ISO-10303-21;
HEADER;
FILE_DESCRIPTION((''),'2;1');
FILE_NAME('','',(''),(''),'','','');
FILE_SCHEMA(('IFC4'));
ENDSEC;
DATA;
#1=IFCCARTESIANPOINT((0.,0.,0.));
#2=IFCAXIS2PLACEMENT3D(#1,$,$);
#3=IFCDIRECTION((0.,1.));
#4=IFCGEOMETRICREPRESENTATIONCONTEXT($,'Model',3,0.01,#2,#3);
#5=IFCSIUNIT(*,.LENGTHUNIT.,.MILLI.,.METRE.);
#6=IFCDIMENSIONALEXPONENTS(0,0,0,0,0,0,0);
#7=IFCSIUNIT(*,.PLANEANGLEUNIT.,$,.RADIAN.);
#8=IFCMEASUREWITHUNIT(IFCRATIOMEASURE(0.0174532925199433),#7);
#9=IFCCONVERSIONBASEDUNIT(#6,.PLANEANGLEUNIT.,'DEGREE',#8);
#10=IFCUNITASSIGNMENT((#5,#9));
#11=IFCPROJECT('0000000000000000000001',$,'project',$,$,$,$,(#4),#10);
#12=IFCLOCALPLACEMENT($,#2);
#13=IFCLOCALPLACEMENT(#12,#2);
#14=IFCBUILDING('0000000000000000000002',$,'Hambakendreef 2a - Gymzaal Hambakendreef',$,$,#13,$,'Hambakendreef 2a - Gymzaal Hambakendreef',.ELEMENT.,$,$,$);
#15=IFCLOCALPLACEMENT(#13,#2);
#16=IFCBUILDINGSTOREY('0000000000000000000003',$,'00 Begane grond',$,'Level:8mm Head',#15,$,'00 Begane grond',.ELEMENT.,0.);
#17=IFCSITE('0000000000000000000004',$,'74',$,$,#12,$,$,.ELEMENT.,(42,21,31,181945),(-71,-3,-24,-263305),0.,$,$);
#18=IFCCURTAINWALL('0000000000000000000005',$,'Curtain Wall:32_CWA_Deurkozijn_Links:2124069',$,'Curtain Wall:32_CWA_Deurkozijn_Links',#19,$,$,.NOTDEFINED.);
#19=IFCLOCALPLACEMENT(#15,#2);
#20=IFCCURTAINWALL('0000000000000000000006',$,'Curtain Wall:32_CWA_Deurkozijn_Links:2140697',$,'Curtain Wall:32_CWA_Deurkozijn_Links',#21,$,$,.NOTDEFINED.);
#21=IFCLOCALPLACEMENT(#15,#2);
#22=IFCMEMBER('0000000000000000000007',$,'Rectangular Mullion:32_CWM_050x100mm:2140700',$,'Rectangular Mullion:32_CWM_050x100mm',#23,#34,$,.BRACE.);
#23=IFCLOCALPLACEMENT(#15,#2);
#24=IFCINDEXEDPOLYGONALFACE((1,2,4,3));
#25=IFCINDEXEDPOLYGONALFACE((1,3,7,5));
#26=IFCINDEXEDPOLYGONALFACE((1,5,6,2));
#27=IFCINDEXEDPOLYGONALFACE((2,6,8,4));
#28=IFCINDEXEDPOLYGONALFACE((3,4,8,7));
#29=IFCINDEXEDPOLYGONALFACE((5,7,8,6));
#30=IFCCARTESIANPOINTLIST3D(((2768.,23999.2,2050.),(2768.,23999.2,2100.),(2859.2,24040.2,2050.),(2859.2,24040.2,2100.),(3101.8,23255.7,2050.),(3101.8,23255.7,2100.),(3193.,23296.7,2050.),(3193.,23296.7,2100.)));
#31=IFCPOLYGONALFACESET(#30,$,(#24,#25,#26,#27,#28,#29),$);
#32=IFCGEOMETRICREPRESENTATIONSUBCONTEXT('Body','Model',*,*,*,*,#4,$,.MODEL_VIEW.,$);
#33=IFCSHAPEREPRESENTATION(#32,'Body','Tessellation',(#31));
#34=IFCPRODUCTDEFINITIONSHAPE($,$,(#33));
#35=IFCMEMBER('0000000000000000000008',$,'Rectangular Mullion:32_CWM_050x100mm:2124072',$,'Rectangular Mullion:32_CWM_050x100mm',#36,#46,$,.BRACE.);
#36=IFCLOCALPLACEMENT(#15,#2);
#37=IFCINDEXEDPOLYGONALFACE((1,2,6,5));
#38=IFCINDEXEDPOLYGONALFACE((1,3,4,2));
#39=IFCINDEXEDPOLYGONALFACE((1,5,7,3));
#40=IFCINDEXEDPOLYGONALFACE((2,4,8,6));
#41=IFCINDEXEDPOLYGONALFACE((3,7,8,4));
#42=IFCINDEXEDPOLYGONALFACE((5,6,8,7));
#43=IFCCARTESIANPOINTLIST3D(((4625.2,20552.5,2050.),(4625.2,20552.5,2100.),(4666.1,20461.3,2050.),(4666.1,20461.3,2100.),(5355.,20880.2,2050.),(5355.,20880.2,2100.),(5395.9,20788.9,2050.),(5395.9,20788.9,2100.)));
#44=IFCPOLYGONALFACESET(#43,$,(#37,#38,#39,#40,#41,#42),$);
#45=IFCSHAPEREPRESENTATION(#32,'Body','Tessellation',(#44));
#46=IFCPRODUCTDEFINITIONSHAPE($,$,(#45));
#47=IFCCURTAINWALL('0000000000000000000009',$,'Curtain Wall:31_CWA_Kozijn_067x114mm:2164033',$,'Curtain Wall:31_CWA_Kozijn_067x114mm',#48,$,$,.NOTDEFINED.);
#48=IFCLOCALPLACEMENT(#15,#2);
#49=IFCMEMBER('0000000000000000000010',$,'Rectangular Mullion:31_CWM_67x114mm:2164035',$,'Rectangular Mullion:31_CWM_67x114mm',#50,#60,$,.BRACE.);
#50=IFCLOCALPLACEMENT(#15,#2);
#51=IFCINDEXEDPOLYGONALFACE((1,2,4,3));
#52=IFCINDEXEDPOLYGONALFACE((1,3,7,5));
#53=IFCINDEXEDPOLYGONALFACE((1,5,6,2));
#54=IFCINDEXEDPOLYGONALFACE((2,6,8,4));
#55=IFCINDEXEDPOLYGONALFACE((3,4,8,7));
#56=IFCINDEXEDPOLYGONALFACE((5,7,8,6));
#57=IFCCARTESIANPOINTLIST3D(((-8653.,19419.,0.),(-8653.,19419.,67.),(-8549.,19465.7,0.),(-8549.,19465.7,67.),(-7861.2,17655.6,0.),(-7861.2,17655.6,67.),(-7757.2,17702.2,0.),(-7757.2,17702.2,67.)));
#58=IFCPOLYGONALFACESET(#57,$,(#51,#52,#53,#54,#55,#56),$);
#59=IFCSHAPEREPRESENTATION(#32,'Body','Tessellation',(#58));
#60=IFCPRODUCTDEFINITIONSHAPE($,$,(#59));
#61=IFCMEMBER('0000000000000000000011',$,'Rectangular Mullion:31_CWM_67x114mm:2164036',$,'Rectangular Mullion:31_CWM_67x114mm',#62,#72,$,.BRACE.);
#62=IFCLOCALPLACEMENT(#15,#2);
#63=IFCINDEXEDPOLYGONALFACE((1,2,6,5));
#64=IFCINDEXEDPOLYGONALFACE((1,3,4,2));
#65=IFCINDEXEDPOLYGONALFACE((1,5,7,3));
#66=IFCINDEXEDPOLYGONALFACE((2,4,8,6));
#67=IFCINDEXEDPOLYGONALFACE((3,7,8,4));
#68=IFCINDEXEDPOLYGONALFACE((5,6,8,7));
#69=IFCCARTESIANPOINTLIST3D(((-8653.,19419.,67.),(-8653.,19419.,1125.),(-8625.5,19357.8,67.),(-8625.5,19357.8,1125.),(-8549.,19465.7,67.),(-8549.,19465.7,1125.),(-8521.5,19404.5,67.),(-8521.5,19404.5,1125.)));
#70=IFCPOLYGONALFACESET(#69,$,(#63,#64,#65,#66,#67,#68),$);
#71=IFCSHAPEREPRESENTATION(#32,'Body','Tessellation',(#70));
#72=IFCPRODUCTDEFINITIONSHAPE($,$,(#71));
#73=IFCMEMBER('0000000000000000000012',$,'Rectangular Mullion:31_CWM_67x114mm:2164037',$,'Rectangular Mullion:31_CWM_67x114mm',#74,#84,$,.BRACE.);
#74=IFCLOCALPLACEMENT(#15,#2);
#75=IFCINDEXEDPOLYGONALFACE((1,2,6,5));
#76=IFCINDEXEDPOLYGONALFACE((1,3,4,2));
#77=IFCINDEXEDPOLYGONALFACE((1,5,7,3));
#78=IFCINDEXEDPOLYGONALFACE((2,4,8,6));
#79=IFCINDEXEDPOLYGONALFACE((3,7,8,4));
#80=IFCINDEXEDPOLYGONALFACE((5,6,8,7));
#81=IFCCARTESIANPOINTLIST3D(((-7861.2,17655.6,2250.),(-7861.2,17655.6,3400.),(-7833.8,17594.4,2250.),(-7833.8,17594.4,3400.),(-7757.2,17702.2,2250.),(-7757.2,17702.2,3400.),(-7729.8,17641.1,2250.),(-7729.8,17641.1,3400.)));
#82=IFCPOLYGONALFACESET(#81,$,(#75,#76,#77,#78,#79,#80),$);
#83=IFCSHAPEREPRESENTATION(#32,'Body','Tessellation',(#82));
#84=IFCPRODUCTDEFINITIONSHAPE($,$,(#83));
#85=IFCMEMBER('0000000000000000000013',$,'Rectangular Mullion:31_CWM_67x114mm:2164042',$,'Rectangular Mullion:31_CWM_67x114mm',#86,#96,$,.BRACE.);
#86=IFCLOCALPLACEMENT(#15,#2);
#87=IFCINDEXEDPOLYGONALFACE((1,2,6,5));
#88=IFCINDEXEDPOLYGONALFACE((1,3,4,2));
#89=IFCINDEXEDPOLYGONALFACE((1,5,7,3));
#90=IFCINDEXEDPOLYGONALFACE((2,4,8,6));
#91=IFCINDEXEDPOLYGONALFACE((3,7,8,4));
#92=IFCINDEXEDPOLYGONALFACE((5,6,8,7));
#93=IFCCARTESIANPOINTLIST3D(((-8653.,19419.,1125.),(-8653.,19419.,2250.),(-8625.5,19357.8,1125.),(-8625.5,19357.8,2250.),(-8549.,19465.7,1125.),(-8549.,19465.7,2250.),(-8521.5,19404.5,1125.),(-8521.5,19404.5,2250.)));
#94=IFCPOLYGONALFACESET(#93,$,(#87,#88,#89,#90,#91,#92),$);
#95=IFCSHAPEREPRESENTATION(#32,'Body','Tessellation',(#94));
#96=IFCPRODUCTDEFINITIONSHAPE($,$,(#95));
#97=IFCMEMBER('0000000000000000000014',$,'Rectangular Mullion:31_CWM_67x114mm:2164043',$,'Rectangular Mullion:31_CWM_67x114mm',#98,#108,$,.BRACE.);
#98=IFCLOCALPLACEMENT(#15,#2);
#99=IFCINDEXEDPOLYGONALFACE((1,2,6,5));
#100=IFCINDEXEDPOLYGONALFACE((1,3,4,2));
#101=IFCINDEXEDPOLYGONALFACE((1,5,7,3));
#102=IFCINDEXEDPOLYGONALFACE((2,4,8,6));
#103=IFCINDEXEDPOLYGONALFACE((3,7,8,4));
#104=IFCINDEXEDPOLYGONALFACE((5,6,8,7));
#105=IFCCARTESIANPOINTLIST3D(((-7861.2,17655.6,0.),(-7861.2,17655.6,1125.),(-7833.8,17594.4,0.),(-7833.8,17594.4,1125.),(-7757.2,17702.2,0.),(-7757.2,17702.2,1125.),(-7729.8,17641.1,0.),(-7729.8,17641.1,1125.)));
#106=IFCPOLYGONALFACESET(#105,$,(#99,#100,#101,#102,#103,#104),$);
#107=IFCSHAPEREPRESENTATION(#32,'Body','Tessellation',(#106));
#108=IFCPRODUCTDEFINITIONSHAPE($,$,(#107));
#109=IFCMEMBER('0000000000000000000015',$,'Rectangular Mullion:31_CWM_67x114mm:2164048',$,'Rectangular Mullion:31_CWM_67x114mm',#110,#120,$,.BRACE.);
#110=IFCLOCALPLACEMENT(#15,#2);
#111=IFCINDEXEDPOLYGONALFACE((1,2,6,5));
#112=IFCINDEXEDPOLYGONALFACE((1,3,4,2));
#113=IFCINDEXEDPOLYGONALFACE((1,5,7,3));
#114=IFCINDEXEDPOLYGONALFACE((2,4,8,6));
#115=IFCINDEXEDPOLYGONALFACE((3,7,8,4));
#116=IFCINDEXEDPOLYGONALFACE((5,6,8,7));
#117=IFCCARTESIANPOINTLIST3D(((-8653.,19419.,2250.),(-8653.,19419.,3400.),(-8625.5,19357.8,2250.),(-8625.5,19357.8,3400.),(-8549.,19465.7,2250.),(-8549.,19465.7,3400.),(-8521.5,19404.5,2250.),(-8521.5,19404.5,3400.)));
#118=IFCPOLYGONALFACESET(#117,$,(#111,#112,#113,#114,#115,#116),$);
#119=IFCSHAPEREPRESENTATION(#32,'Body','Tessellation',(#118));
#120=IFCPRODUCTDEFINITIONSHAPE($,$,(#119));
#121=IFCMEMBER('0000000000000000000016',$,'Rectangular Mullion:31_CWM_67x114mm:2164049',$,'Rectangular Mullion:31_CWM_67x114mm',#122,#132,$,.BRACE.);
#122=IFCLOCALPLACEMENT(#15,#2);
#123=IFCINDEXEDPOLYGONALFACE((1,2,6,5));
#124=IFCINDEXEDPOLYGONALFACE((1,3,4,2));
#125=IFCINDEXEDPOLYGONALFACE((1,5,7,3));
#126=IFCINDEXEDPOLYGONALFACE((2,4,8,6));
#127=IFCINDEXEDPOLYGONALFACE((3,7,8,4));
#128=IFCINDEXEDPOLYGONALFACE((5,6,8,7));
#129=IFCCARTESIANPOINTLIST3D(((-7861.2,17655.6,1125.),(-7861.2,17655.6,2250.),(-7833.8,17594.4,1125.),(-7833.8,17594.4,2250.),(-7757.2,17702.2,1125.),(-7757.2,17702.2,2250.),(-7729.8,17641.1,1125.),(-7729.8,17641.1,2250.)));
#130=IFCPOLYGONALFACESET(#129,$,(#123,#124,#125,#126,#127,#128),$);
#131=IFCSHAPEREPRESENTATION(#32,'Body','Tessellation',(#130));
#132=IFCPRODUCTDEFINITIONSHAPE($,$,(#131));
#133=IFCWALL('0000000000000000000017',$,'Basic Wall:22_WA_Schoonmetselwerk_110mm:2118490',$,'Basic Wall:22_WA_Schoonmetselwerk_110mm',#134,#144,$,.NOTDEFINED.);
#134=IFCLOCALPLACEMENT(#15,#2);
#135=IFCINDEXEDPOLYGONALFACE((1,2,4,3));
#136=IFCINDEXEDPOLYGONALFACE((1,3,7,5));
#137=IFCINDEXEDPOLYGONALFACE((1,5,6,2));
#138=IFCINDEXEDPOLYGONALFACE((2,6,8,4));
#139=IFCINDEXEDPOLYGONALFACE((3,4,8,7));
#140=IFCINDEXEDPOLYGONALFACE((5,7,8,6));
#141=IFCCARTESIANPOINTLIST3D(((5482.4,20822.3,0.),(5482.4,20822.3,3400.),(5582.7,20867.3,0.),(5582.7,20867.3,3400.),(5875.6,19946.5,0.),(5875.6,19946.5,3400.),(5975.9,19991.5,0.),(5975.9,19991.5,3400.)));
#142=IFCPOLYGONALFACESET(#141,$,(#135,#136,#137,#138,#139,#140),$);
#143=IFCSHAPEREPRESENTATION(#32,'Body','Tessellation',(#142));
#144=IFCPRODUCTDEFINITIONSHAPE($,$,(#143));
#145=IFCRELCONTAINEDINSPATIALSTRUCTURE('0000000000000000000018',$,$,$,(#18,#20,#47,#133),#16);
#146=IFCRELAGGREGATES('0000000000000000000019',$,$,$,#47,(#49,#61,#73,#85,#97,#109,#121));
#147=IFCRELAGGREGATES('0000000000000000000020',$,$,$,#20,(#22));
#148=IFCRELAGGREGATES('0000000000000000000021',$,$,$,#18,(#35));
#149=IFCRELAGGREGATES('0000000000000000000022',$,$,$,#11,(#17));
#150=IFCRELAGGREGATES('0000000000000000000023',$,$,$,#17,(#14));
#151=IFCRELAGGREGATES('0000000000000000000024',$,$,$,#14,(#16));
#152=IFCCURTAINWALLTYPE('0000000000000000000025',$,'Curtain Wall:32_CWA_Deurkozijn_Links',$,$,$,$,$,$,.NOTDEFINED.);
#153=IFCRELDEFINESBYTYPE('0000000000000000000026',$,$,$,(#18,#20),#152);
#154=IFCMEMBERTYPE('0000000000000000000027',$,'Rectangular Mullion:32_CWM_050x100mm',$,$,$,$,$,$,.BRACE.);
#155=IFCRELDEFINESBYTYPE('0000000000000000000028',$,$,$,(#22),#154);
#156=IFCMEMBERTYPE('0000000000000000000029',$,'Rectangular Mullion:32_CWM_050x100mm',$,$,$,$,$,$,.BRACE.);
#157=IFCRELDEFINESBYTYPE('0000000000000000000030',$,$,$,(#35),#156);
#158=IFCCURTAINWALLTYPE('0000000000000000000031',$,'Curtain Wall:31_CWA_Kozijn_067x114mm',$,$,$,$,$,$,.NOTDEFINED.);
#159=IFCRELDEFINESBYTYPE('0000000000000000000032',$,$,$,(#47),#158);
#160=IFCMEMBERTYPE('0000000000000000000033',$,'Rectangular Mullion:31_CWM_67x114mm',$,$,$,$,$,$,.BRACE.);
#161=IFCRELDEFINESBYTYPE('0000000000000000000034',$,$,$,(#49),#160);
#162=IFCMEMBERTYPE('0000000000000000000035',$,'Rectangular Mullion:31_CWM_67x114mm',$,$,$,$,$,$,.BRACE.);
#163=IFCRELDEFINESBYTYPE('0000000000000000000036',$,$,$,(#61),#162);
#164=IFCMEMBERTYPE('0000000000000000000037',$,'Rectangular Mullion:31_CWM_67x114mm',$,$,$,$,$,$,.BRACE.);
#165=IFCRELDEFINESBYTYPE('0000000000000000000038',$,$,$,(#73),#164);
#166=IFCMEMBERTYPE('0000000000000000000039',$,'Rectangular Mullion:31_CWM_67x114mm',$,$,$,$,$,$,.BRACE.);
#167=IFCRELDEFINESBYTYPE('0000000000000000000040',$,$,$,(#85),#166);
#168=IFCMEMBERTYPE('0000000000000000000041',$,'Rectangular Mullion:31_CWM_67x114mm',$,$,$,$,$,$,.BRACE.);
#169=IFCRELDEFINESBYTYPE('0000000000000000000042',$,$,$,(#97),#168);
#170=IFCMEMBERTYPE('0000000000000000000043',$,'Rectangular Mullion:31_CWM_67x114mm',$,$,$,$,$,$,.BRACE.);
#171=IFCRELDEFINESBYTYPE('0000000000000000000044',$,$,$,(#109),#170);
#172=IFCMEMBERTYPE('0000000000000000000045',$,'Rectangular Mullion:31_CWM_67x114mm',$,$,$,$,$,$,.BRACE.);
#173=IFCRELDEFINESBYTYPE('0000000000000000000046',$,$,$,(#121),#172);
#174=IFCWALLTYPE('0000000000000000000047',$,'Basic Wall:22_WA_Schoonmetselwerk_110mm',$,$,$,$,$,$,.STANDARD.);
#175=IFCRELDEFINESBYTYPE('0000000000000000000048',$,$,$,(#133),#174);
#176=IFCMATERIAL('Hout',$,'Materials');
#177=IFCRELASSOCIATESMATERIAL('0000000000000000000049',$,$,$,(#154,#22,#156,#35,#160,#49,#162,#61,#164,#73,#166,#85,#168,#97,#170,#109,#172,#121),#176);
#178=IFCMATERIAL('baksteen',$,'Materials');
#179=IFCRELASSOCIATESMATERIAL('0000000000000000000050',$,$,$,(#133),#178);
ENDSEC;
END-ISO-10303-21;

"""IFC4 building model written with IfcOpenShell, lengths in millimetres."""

from ifc_helpers import new_model, entity, si_unit, converted_unit, direction, frame, origin, place, context, subcontext, project, spatial, indexed_curve, outline, extrude, source, transform, mapped, material, type_object, type_shapes, element, aggregate, save


model = new_model("IFC4")

# Units and contexts
model_context = context("Model", 3, precision=0.01, world=origin(), true_north=direction((0.0, 1.0)))
body_context = subcontext(model_context, "Body", "Model", "MODEL_VIEW")
ifc_project = project(units=[si_unit("LENGTHUNIT", "METRE", prefix="MILLI"), converted_unit("PLANEANGLEUNIT", "DEGREE", entity("IfcRatioMeasure", 0.0174532925199433), si_unit("PLANEANGLEUNIT", "RADIAN"), dimensions=[0, 0, 0, 0, 0, 0, 0])], contexts=[model_context])

# Site, building, storey
site_placement = place(None, origin())
site = spatial("IfcSite", under=ifc_project, at=site_placement, Name="74", CompositionType="ELEMENT", RefLatitude=(42, 21, 31, 181945), RefLongitude=(-71, -3, -24, -263305), RefElevation=0.0)
building_placement = place(site_placement, origin())
building = spatial("IfcBuilding", under=site, at=building_placement, Name="Hambakendreef 2a - Gymzaal Hambakendreef", LongName="Hambakendreef 2a - Gymzaal Hambakendreef", CompositionType="ELEMENT")
storey_placement = place(building_placement, origin())
storey = spatial("IfcBuildingStorey", under=building, at=storey_placement, Name="00 Begane grond", ObjectType="Level:8mm Head", LongName="00 Begane grond", CompositionType="ELEMENT", Elevation=0.0)

# Curtain walls
curtain_wall_type_1 = type_object("IfcCurtainWallType", Name="Curtain Wall:32_CWA_Deurkozijn_Links", PredefinedType="NOTDEFINED")
curtain_wall_1_placement = place(storey_placement, origin())
curtain_wall_1 = element("IfcCurtainWall", 1, at=curtain_wall_1_placement, inside=storey, type_object=curtain_wall_type_1, Name="Curtain Wall:32_CWA_Deurkozijn_Links:2124069", ObjectType="Curtain Wall:32_CWA_Deurkozijn_Links", PredefinedType="NOTDEFINED")
ifc_material_1 = material(Name="Hout", Category="Materials")
curtain_wall_2_placement = place(storey_placement, origin())
curtain_wall_2 = element("IfcCurtainWall", 2, at=curtain_wall_2_placement, inside=storey, type_object=curtain_wall_type_1, Name="Curtain Wall:32_CWA_Deurkozijn_Links:2140697", ObjectType="Curtain Wall:32_CWA_Deurkozijn_Links", PredefinedType="NOTDEFINED")

# Members
member_type_1 = type_object("IfcMemberType", Name="Rectangular Mullion:32_CWM_050x100mm", PredefinedType="BRACE", material=ifc_material_1)
shared_shape_1 = source(origin(), body_context, "Body", "SweptSolid", [
    extrude(outline(indexed_curve([(-50.0, -25.0), (50.0, -25.0), (50.0, 25.0), (-50.0, 25.0), (-50.0, -25.0)], self_intersect=False)), frame((-25.0, 0.0, -815.0), z_axis=(0.0, 0.0, 1.0), x_axis=(0.0, -1.0, 0.0)), (0.0, 0.0, 1.0), 815.0),
])
type_shapes(member_type_1, [shared_shape_1])
member_1_placement = place(storey_placement, frame((3147.4, 23276.2, 2100.0), z_axis=(0.40959, -0.91227, 0.0), x_axis=(0.0, 0.0, 1.0)))
member_1 = element("IfcMember", 3, at=member_1_placement, type_object=member_type_1, material=ifc_material_1, Name="Rectangular Mullion:32_CWM_050x100mm:2140700", ObjectType="Rectangular Mullion:32_CWM_050x100mm", PredefinedType="BRACE", context=body_context, shape_type="MappedRepresentation", body=[
    mapped(shared_shape_1, transform((0.0, 0.0, 0.0), scale=1.0)),
])
member_type_2 = type_object("IfcMemberType", Name="Rectangular Mullion:32_CWM_050x100mm", PredefinedType="BRACE", material=ifc_material_1)
shared_shape_2 = source(origin(), body_context, "Body", "SweptSolid", [
    extrude(outline(indexed_curve([(-50.0, -25.0), (50.0, -25.0), (50.0, 25.0), (-50.0, 25.0), (-50.0, -25.0)], self_intersect=False)), frame((-25.0, 0.0, -800.0), z_axis=(0.0, 0.0, 1.0), x_axis=(0.0, -1.0, 0.0)), (0.0, 0.0, 1.0), 800.0),
])
type_shapes(member_type_2, [shared_shape_2])
member_2_placement = place(storey_placement, frame((5375.5, 20834.6, 2100.0), z_axis=(0.91227, 0.40959, 0.0), x_axis=(0.0, 0.0, 1.0)))
member_2 = element("IfcMember", 4, at=member_2_placement, type_object=member_type_2, material=ifc_material_1, Name="Rectangular Mullion:32_CWM_050x100mm:2124072", ObjectType="Rectangular Mullion:32_CWM_050x100mm", PredefinedType="BRACE", context=body_context, shape_type="MappedRepresentation", body=[
    mapped(shared_shape_2, transform((0.0, 0.0, 0.0), scale=1.0)),
])

# Curtain wall, members
curtain_wall_type_2 = type_object("IfcCurtainWallType", Name="Curtain Wall:31_CWA_Kozijn_067x114mm", PredefinedType="NOTDEFINED")
curtain_wall_3_placement = place(storey_placement, origin())
curtain_wall_3 = element("IfcCurtainWall", 5, at=curtain_wall_3_placement, inside=storey, type_object=curtain_wall_type_2, Name="Curtain Wall:31_CWA_Kozijn_067x114mm:2164033", ObjectType="Curtain Wall:31_CWA_Kozijn_067x114mm", PredefinedType="NOTDEFINED")
member_type_3 = type_object("IfcMemberType", Name="Rectangular Mullion:31_CWM_67x114mm", PredefinedType="BRACE", material=ifc_material_1)
shared_shape_3 = source(origin(), body_context, "Body", "SweptSolid", [
    extrude(outline(indexed_curve([(-57.0, -33.5), (57.0, -33.5), (57.0, 33.5), (-57.0, 33.5), (-57.0, -33.5)], self_intersect=False)), frame((-33.5, 0.0, -1933.0), z_axis=(0.0, 0.0, 1.0), x_axis=(0.0, -1.0, 0.0)), (0.0, 0.0, 1.0), 1933.0),
])
type_shapes(member_type_3, [shared_shape_3])
member_3_placement = place(storey_placement, frame((-7809.2, 17678.9, 0.0), z_axis=(0.40959, -0.91227, 0.0), x_axis=(0.0, 0.0, -1.0)))
member_3 = element("IfcMember", 6, at=member_3_placement, type_object=member_type_3, material=ifc_material_1, Name="Rectangular Mullion:31_CWM_67x114mm:2164035", ObjectType="Rectangular Mullion:31_CWM_67x114mm", PredefinedType="BRACE", context=body_context, shape_type="MappedRepresentation", body=[
    mapped(shared_shape_3, transform((0.0, 0.0, 0.0), scale=1.0)),
])
member_type_4 = type_object("IfcMemberType", Name="Rectangular Mullion:31_CWM_67x114mm", PredefinedType="BRACE", material=ifc_material_1)
shared_shape_4 = source(origin(), body_context, "Body", "SweptSolid", [
    extrude(outline(indexed_curve([(-57.0, -33.5), (57.0, -33.5), (57.0, 33.5), (-57.0, 33.5), (-57.0, -33.5)], self_intersect=False)), frame((-33.5, 0.0, -1058.0), z_axis=(0.0, 0.0, 1.0), x_axis=(0.0, -1.0, 0.0)), (0.0, 0.0, 1.0), 1058.0),
])
type_shapes(member_type_4, [shared_shape_4])
member_4_placement = place(storey_placement, frame((-8601.0, 19442.3, 67.0), z_axis=(0.0, 0.0, -1.0), x_axis=(-0.40959, 0.91227, 0.0)))
member_4 = element("IfcMember", 7, at=member_4_placement, type_object=member_type_4, material=ifc_material_1, Name="Rectangular Mullion:31_CWM_67x114mm:2164036", ObjectType="Rectangular Mullion:31_CWM_67x114mm", PredefinedType="BRACE", context=body_context, shape_type="MappedRepresentation", body=[
    mapped(shared_shape_4, transform((0.0, 0.0, 0.0), scale=1.0)),
])
member_type_5 = type_object("IfcMemberType", Name="Rectangular Mullion:31_CWM_67x114mm", PredefinedType="BRACE", material=ifc_material_1)
shared_shape_5 = source(origin(), body_context, "Body", "SweptSolid", [
    extrude(outline(indexed_curve([(-57.0, -33.5), (57.0, -33.5), (57.0, 33.5), (-57.0, 33.5), (-57.0, -33.5)], self_intersect=False)), frame((-33.5, 0.0, -1150.0), z_axis=(0.0, 0.0, 1.0), x_axis=(0.0, -1.0, 0.0)), (0.0, 0.0, 1.0), 1150.0),
])
type_shapes(member_type_5, [shared_shape_5])
member_5_placement = place(storey_placement, frame((-7781.8, 17617.8, 3400.0), z_axis=(0.0, 0.0, 1.0), x_axis=(0.40959, -0.91227, 0.0)))
member_5 = element("IfcMember", 8, at=member_5_placement, type_object=member_type_5, material=ifc_material_1, Name="Rectangular Mullion:31_CWM_67x114mm:2164037", ObjectType="Rectangular Mullion:31_CWM_67x114mm", PredefinedType="BRACE", context=body_context, shape_type="MappedRepresentation", body=[
    mapped(shared_shape_5, transform((0.0, 0.0, 0.0), scale=1.0)),
])
member_type_6 = type_object("IfcMemberType", Name="Rectangular Mullion:31_CWM_67x114mm", PredefinedType="BRACE", material=ifc_material_1)
shared_shape_6 = source(origin(), body_context, "Body", "SweptSolid", [
    extrude(outline(indexed_curve([(-57.0, -33.5), (57.0, -33.5), (57.0, 33.5), (-57.0, 33.5), (-57.0, -33.5)], self_intersect=False)), frame((-33.5, 0.0, -1125.0), z_axis=(0.0, 0.0, 1.0), x_axis=(0.0, -1.0, 0.0)), (0.0, 0.0, 1.0), 1125.0),
])
type_shapes(member_type_6, [shared_shape_6])
member_6_placement = place(storey_placement, frame((-8601.0, 19442.3, 1125.0), z_axis=(0.0, 0.0, -1.0), x_axis=(-0.40959, 0.91227, 0.0)))
member_6 = element("IfcMember", 9, at=member_6_placement, type_object=member_type_6, material=ifc_material_1, Name="Rectangular Mullion:31_CWM_67x114mm:2164042", ObjectType="Rectangular Mullion:31_CWM_67x114mm", PredefinedType="BRACE", context=body_context, shape_type="MappedRepresentation", body=[
    mapped(shared_shape_6, transform((0.0, 0.0, 0.0), scale=1.0)),
])
member_type_7 = type_object("IfcMemberType", Name="Rectangular Mullion:31_CWM_67x114mm", PredefinedType="BRACE", material=ifc_material_1)
shared_shape_7 = source(origin(), body_context, "Body", "SweptSolid", [
    extrude(outline(indexed_curve([(-57.0, -33.5), (57.0, -33.5), (57.0, 33.5), (-57.0, 33.5), (-57.0, -33.5)], self_intersect=False)), frame((-33.5, 0.0, -1125.0), z_axis=(0.0, 0.0, 1.0), x_axis=(0.0, -1.0, 0.0)), (0.0, 0.0, 1.0), 1125.0),
])
type_shapes(member_type_7, [shared_shape_7])
member_7_placement = place(storey_placement, frame((-7781.8, 17617.8, 1125.0), z_axis=(0.0, 0.0, 1.0), x_axis=(0.40959, -0.91227, 0.0)))
member_7 = element("IfcMember", 10, at=member_7_placement, type_object=member_type_7, material=ifc_material_1, Name="Rectangular Mullion:31_CWM_67x114mm:2164043", ObjectType="Rectangular Mullion:31_CWM_67x114mm", PredefinedType="BRACE", context=body_context, shape_type="MappedRepresentation", body=[
    mapped(shared_shape_7, transform((0.0, 0.0, 0.0), scale=1.0)),
])
member_type_8 = type_object("IfcMemberType", Name="Rectangular Mullion:31_CWM_67x114mm", PredefinedType="BRACE", material=ifc_material_1)
shared_shape_8 = source(origin(), body_context, "Body", "SweptSolid", [
    extrude(outline(indexed_curve([(-57.0, -33.5), (57.0, -33.5), (57.0, 33.5), (-57.0, 33.5), (-57.0, -33.5)], self_intersect=False)), frame((-33.5, 0.0, -1150.0), z_axis=(0.0, 0.0, 1.0), x_axis=(0.0, -1.0, 0.0)), (0.0, 0.0, 1.0), 1150.0),
])
type_shapes(member_type_8, [shared_shape_8])
member_8_placement = place(storey_placement, frame((-8601.0, 19442.3, 2250.0), z_axis=(0.0, 0.0, -1.0), x_axis=(-0.40959, 0.91227, 0.0)))
member_8 = element("IfcMember", 11, at=member_8_placement, type_object=member_type_8, material=ifc_material_1, Name="Rectangular Mullion:31_CWM_67x114mm:2164048", ObjectType="Rectangular Mullion:31_CWM_67x114mm", PredefinedType="BRACE", context=body_context, shape_type="MappedRepresentation", body=[
    mapped(shared_shape_8, transform((0.0, 0.0, 0.0), scale=1.0)),
])
member_type_9 = type_object("IfcMemberType", Name="Rectangular Mullion:31_CWM_67x114mm", PredefinedType="BRACE", material=ifc_material_1)
shared_shape_9 = source(origin(), body_context, "Body", "SweptSolid", [
    extrude(outline(indexed_curve([(-57.0, -33.5), (57.0, -33.5), (57.0, 33.5), (-57.0, 33.5), (-57.0, -33.5)], self_intersect=False)), frame((-33.5, 0.0, -1125.0), z_axis=(0.0, 0.0, 1.0), x_axis=(0.0, -1.0, 0.0)), (0.0, 0.0, 1.0), 1125.0),
])
type_shapes(member_type_9, [shared_shape_9])
member_9_placement = place(storey_placement, frame((-7781.8, 17617.8, 2250.0), z_axis=(0.0, 0.0, 1.0), x_axis=(0.40959, -0.91227, 0.0)))
member_9 = element("IfcMember", 12, at=member_9_placement, type_object=member_type_9, material=ifc_material_1, Name="Rectangular Mullion:31_CWM_67x114mm:2164049", ObjectType="Rectangular Mullion:31_CWM_67x114mm", PredefinedType="BRACE", context=body_context, shape_type="MappedRepresentation", body=[
    mapped(shared_shape_9, transform((0.0, 0.0, 0.0), scale=1.0)),
])
aggregate(curtain_wall_3, [member_3, member_4, member_5, member_6, member_7, member_8, member_9])

# Shared definitions
ifc_material_2 = material(Name="baksteen", Category="Materials")

# Wall
wall_type_1 = type_object("IfcWallType", Name="Basic Wall:22_WA_Schoonmetselwerk_110mm", PredefinedType="STANDARD")
wall_1_placement = place(storey_placement, frame((5532.5, 20844.8, 0.0), z_axis=(0.0, 0.0, 1.0), x_axis=(0.40959, -0.91227, 0.0)))
element("IfcWall", 13, at=wall_1_placement, inside=storey, type_object=wall_type_1, material=ifc_material_2, Name="Basic Wall:22_WA_Schoonmetselwerk_110mm:2118490", ObjectType="Basic Wall:22_WA_Schoonmetselwerk_110mm", PredefinedType="NOTDEFINED", context=body_context, shape_type="SweptSolid", body=[
    extrude(outline(indexed_curve([(960.0, 55.0), (0.0, 55.0), (0.0, -55.0), (960.0, -55.0), (960.0, 55.0)], self_intersect=False)), origin(), (0.0, 0.0, 1.0), 3400.0),
])

aggregate(curtain_wall_2, [member_1])
aggregate(curtain_wall_1, [member_2])

save(model, "model.ifc")
